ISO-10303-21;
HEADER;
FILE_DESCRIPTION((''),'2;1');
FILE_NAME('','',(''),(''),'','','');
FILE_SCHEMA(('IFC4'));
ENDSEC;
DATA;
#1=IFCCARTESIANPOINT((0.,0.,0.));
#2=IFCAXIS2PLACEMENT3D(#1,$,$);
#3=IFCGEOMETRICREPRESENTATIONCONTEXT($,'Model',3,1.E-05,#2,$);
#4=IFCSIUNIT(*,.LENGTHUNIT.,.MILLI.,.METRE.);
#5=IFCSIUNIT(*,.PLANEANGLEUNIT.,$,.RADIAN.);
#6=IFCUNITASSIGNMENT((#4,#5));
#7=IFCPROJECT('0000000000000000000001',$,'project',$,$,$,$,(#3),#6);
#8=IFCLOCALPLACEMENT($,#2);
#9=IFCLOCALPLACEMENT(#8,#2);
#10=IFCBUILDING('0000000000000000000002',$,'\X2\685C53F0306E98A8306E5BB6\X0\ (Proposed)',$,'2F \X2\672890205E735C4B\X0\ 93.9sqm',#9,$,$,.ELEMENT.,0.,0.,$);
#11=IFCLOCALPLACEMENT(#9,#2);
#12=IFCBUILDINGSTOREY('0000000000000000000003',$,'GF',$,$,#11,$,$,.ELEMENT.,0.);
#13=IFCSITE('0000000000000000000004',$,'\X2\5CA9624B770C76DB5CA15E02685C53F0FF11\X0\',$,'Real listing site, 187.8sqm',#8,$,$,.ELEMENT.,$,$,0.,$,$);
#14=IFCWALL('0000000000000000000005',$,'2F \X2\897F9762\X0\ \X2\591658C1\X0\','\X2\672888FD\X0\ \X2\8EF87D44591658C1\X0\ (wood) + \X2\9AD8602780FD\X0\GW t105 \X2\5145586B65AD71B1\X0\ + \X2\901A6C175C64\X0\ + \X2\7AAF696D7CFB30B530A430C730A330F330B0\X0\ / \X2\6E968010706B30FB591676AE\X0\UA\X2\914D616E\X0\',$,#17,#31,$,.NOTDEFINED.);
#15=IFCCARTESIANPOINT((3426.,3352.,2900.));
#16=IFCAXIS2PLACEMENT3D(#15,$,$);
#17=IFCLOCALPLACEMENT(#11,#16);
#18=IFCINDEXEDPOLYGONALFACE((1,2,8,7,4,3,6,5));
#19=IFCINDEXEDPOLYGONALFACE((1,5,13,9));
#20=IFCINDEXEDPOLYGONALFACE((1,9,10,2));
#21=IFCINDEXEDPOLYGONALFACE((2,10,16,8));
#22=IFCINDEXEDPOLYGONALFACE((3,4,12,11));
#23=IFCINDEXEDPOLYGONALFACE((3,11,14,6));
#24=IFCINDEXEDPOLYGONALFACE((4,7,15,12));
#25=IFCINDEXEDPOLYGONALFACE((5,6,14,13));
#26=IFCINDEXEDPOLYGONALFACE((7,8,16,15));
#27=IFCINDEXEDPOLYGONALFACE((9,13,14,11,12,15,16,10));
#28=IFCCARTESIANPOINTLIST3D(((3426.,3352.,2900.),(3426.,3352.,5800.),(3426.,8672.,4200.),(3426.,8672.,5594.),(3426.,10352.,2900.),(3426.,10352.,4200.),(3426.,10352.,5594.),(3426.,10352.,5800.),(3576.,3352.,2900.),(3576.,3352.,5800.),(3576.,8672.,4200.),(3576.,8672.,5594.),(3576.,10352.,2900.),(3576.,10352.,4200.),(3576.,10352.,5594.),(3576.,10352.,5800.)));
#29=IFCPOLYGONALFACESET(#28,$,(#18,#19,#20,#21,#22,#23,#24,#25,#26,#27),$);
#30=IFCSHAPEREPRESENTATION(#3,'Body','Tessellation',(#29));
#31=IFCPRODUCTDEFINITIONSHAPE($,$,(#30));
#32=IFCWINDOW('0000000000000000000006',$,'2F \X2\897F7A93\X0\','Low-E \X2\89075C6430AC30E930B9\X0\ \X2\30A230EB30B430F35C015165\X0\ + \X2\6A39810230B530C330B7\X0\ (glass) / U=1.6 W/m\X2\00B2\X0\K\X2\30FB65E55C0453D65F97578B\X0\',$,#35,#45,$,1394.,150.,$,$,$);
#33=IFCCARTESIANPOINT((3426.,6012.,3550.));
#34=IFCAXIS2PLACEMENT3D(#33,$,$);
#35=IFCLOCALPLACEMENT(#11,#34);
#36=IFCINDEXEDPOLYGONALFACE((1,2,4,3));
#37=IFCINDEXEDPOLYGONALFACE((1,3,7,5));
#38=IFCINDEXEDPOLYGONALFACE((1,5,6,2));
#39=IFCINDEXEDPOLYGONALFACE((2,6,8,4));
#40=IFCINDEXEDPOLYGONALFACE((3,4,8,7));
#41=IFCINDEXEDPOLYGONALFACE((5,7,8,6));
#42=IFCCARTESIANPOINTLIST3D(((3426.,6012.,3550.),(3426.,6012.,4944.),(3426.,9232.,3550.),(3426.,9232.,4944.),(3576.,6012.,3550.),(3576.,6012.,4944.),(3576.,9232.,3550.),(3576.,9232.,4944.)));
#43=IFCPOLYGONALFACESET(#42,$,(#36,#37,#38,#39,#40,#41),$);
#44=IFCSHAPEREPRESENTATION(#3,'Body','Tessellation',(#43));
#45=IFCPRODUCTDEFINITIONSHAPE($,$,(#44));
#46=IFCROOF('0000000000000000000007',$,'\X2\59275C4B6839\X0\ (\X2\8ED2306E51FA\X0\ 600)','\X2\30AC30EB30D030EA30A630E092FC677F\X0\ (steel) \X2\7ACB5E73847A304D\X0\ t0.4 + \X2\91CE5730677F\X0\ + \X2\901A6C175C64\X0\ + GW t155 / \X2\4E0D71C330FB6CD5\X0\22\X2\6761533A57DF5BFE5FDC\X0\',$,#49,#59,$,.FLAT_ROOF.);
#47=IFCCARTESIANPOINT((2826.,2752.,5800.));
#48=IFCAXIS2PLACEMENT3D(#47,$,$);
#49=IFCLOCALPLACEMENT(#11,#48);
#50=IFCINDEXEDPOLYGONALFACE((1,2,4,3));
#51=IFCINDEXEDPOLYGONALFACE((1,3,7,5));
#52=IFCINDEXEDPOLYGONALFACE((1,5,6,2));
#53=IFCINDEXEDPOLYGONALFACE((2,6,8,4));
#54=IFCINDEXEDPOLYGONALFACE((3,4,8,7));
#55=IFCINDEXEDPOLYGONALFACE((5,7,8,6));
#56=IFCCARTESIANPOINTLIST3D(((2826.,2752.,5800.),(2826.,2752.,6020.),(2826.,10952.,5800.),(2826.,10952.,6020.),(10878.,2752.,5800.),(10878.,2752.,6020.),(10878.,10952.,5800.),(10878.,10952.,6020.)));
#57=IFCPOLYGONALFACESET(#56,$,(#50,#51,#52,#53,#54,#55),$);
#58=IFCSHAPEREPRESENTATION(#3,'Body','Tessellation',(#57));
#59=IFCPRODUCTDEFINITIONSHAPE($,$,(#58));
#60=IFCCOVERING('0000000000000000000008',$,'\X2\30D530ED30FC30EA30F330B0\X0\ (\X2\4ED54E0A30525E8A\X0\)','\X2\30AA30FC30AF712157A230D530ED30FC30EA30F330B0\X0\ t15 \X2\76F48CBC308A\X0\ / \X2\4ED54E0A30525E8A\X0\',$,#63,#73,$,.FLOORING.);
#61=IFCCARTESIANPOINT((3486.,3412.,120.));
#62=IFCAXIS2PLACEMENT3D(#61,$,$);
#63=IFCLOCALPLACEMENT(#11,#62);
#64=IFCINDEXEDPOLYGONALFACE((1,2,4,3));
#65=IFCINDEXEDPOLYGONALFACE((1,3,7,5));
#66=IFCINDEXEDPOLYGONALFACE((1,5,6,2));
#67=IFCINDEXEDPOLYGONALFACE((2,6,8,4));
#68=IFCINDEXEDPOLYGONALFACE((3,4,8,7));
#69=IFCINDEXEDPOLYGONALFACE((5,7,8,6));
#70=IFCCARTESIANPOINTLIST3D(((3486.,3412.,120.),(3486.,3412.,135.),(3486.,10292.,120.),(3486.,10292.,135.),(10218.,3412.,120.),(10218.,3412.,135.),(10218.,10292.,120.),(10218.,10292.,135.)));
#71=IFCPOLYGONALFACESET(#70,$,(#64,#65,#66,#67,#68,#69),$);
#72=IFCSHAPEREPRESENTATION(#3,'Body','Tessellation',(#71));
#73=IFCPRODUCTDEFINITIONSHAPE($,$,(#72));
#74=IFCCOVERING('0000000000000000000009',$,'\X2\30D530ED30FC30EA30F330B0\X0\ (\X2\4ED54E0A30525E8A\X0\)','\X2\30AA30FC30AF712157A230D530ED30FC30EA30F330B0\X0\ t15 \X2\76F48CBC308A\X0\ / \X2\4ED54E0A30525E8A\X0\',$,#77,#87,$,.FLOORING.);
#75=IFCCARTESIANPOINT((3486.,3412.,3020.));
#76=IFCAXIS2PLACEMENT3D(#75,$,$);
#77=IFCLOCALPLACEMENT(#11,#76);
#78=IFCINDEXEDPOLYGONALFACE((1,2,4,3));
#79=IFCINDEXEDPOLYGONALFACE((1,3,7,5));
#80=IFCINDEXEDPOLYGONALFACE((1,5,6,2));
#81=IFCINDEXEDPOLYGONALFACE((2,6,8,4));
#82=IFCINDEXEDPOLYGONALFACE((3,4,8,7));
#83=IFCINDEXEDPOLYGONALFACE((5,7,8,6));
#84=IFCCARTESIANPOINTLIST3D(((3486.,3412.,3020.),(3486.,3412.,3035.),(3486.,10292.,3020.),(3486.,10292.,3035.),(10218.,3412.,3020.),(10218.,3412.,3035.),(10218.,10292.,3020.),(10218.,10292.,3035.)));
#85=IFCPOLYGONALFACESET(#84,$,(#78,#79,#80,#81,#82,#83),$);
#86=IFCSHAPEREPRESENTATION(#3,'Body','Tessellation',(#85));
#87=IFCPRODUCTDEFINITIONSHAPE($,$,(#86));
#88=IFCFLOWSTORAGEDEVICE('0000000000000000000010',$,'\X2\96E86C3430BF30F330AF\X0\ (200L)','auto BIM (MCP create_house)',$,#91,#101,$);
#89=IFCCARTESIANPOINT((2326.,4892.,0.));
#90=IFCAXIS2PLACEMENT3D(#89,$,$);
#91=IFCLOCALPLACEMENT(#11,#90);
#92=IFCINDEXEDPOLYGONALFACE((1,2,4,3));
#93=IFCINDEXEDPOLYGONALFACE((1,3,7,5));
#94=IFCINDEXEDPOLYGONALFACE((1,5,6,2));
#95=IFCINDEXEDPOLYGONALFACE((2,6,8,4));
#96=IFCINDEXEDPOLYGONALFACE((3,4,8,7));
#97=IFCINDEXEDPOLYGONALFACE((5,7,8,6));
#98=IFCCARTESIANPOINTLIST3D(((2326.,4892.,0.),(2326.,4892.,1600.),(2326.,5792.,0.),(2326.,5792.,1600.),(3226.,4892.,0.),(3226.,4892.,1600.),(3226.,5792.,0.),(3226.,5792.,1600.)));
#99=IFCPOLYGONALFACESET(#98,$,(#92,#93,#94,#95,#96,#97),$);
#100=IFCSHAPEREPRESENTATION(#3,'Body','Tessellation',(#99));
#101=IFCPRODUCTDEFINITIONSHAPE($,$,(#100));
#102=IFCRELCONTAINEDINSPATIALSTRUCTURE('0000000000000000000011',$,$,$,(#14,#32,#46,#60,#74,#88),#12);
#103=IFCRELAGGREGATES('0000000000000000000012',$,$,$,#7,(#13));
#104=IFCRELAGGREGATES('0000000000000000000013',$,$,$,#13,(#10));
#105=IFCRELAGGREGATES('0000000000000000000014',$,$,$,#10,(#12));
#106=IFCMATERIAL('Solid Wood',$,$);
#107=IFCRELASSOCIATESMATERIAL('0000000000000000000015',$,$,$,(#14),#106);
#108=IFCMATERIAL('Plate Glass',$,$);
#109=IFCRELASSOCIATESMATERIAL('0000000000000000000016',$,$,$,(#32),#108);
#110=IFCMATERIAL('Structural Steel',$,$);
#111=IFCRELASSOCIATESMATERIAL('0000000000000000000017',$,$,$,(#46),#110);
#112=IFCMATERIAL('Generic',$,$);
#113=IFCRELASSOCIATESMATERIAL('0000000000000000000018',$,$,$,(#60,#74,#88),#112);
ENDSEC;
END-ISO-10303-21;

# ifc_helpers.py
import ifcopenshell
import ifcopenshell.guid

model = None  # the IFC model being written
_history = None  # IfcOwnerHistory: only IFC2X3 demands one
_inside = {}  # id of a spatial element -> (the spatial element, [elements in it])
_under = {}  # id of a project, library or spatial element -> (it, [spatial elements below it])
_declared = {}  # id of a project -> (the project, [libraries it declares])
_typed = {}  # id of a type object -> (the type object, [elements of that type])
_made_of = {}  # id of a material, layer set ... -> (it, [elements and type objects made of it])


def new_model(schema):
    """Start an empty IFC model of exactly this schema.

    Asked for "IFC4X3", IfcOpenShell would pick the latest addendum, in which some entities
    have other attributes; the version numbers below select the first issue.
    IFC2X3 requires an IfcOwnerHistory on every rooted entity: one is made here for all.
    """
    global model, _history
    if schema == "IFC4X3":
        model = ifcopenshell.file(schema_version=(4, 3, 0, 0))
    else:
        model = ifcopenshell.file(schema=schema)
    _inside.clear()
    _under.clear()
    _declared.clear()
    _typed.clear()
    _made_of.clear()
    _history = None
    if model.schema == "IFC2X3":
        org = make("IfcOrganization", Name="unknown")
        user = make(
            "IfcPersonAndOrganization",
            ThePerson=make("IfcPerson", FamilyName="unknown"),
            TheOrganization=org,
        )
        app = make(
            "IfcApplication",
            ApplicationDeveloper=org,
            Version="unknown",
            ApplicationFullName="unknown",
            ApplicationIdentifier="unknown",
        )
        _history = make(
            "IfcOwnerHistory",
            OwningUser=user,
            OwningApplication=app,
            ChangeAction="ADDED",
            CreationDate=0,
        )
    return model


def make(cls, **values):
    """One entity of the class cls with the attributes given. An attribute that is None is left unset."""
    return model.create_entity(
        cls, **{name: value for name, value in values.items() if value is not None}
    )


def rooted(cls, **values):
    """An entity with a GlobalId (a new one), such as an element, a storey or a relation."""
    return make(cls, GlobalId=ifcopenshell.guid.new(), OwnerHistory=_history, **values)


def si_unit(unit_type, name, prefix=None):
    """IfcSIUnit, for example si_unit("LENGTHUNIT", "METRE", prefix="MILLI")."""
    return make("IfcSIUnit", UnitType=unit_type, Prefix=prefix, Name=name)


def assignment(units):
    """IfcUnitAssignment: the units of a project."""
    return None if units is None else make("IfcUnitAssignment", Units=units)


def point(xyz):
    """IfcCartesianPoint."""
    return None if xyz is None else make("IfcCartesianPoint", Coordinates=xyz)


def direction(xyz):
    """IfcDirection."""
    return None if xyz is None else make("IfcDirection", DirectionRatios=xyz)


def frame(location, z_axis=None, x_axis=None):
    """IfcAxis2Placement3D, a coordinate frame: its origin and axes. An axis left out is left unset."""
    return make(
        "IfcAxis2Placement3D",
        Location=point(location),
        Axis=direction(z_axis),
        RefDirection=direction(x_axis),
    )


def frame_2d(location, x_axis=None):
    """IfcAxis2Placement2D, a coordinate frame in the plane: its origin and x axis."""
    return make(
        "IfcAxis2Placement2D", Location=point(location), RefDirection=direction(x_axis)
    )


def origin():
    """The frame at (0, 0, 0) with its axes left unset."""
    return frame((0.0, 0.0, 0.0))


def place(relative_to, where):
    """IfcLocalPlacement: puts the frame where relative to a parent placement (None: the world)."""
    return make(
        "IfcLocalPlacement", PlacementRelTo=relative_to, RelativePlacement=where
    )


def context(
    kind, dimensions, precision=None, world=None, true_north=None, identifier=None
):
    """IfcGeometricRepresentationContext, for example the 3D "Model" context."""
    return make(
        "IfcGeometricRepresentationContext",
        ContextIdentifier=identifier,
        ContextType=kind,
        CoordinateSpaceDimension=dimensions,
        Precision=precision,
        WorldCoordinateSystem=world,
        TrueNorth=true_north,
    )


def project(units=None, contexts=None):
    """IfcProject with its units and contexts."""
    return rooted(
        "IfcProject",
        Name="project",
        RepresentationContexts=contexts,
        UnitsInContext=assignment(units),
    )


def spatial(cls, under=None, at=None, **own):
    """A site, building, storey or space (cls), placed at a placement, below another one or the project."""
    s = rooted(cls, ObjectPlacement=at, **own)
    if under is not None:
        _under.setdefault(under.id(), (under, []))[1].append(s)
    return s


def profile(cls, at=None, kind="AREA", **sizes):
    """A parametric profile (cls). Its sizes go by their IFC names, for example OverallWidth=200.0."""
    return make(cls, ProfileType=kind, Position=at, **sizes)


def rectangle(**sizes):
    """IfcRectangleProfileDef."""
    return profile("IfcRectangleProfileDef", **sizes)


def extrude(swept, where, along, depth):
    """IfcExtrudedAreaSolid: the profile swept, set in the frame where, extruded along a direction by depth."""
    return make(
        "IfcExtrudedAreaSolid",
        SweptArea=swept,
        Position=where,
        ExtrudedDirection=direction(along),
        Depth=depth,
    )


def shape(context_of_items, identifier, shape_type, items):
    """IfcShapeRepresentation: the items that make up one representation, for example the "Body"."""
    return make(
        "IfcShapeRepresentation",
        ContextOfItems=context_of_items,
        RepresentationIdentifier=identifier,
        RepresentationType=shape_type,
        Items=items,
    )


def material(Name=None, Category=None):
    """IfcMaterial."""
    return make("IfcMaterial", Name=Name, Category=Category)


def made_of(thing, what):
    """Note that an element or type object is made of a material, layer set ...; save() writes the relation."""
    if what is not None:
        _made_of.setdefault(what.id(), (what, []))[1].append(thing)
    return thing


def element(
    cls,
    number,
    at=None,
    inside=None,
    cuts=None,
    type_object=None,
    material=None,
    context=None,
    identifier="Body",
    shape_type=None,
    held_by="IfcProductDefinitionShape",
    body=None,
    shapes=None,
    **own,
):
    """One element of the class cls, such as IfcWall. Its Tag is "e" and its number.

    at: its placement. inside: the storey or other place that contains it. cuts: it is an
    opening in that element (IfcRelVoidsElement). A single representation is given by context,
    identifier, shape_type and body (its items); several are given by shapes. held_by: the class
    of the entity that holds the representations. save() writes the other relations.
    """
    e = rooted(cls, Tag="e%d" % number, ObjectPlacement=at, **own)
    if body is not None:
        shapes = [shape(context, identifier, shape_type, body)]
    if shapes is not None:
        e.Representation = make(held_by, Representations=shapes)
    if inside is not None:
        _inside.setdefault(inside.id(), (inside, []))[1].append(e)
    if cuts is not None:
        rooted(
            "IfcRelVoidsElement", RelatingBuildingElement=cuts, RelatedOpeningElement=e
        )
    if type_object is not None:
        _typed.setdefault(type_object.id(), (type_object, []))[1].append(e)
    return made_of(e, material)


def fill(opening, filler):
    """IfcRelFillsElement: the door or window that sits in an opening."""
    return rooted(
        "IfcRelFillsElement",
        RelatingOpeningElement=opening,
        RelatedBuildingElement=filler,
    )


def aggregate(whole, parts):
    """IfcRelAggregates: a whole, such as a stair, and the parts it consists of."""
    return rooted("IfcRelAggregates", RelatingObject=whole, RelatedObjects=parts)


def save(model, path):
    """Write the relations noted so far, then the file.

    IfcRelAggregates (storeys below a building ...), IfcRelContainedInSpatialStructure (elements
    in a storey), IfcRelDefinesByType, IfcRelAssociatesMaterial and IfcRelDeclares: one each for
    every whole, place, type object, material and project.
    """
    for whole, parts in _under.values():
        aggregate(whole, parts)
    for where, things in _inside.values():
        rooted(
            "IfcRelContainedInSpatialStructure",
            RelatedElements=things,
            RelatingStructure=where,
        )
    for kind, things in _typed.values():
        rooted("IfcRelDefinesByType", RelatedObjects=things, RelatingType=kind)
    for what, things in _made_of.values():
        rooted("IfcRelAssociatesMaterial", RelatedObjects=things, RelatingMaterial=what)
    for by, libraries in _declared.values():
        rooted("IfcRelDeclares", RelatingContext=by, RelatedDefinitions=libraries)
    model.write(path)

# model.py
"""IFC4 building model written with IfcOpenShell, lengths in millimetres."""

from ifc_helpers import new_model, si_unit, frame, frame_2d, origin, place, context, project, spatial, rectangle, extrude, material, element, fill, save


model = new_model("IFC4")

# Units and contexts
model_context = context("Model", 3, precision=1e-05, world=origin())
ifc_project = project(units=[si_unit("LENGTHUNIT", "METRE", prefix="MILLI"), si_unit("PLANEANGLEUNIT", "RADIAN")], contexts=[model_context])

# Site, building, storey
site_placement = place(None, origin())
site = spatial("IfcSite", under=ifc_project, at=site_placement, Name="岩手県盛岡市桜台１", ObjectType="Real listing site, 187.8sqm", CompositionType="ELEMENT", RefElevation=0.0)
building_placement = place(site_placement, origin())
building = spatial("IfcBuilding", under=site, at=building_placement, Name="桜台の風の家 (Proposed)", ObjectType="2F 木造平屋 93.9sqm", CompositionType="ELEMENT", ElevationOfRefHeight=0.0, ElevationOfTerrain=0.0)
storey_placement = place(building_placement, origin())
storey = spatial("IfcBuildingStorey", under=building, at=storey_placement, Name="GF", CompositionType="ELEMENT", Elevation=0.0)

# Shared definitions
ifc_material_1 = material(Name="Solid Wood")

# Shared definitions
ifc_material_2 = material(Name="Plate Glass")

# Wall, opening, window
wall_1_placement = place(storey_placement, frame((3426.0, 3352.0, 2900.0)))
wall_1 = element("IfcWall", 1, at=wall_1_placement, inside=storey, material=ifc_material_1, Name="2F 西面 外壁", Description="木製 軸組外壁 (wood) + 高性能GW t105 充填断熱 + 通気層 + 窯業系サイディング / 準耐火・外皮UA配慮", PredefinedType="NOTDEFINED", context=model_context, shape_type="SweptSolid", body=[
    extrude(rectangle(XDim=150.0, YDim=7000.0, at=frame_2d((75.0, 3500.0))), frame((3426.0, 3352.0, 2900.0)), (0.0, 0.0, 1.0), 2900.0),
])
opening_1_placement = place(storey_placement, frame((3426.0, 6012.0, 3550.0)))
opening_1 = element("IfcOpeningElement", 2, at=opening_1_placement, cuts=wall_1, PredefinedType="NOTDEFINED", context=model_context, shape_type="SweptSolid", body=[
    extrude(rectangle(XDim=150.0, YDim=3220.0, at=frame_2d((75.0, 1610.0))), frame((3426.0, 6012.0, 3550.0)), (0.0, 0.0, 1.0), 1394.0),
])
window_1_placement = place(storey_placement, frame((3426.0, 6012.0, 3550.0)))
window_1 = element("IfcWindow", 3, at=window_1_placement, inside=storey, material=ifc_material_2, Name="2F 西窓", Description="Low-E 複層ガラス アルゴン封入 + 樹脂サッシ (glass) / U=1.6 W/m²K・日射取得型", OverallHeight=1394.0, OverallWidth=150.0, context=model_context, shape_type="SweptSolid", body=[
    extrude(rectangle(XDim=150.0, YDim=3220.0, at=frame_2d((75.0, 1610.0))), frame((3426.0, 6012.0, 3550.0)), (0.0, 0.0, 1.0), 1394.0),
])
fill(opening_1, window_1)

# Roof
ifc_material_3 = material(Name="Structural Steel")
roof_placement = place(storey_placement, frame((2826.0, 2752.0, 5800.0)))
element("IfcRoof", 4, at=roof_placement, inside=storey, material=ifc_material_3, Name="大屋根 (軒の出 600)", Description="ガルバリウム鋼板 (steel) 立平葺き t0.4 + 野地板 + 通気層 + GW t155 / 不燃・法22条区域対応", PredefinedType="FLAT_ROOF", context=model_context, shape_type="SweptSolid", body=[
    extrude(rectangle(XDim=8052.0, YDim=8200.0, at=frame_2d((4026.0, 4100.0))), frame((2826.0, 2752.0, 5800.0)), (0.0, 0.0, 1.0), 220.0),
])

# Coverings
ifc_material_4 = material(Name="Generic")
covering_1_placement = place(storey_placement, frame((3486.0, 3412.0, 120.0)))
element("IfcCovering", 5, at=covering_1_placement, inside=storey, material=ifc_material_4, Name="フローリング (仕上げ床)", Description="オーク無垢フローリング t15 直貼り / 仕上げ床", PredefinedType="FLOORING", context=model_context, shape_type="SweptSolid", body=[
    extrude(rectangle(XDim=6732.0, YDim=6880.0, at=frame_2d((3366.0, 3440.0))), frame((3486.0, 3412.0, 120.0)), (0.0, 0.0, 1.0), 15.0),
])
covering_2_placement = place(storey_placement, frame((3486.0, 3412.0, 3020.0)))
element("IfcCovering", 6, at=covering_2_placement, inside=storey, material=ifc_material_4, Name="フローリング (仕上げ床)", Description="オーク無垢フローリング t15 直貼り / 仕上げ床", PredefinedType="FLOORING", context=model_context, shape_type="SweptSolid", body=[
    extrude(rectangle(XDim=6732.0, YDim=6880.0, at=frame_2d((3366.0, 3440.0))), frame((3486.0, 3412.0, 3020.0)), (0.0, 0.0, 1.0), 15.0),
])

# Flow storage device
flow_storage_device_placement = place(storey_placement, frame((2326.0, 4892.0, 0.0)))
element("IfcFlowStorageDevice", 7, at=flow_storage_device_placement, inside=storey, material=ifc_material_4, Name="雨水タンク (200L)", Description="auto BIM (MCP create_house)", context=model_context, shape_type="SweptSolid", body=[
    extrude(rectangle(XDim=900.0, YDim=900.0, at=frame_2d((450.0, 450.0))), frame((2326.0, 4892.0, 0.0)), (0.0, 0.0, 1.0), 1600.0),
])

save(model, "model.ifc")
